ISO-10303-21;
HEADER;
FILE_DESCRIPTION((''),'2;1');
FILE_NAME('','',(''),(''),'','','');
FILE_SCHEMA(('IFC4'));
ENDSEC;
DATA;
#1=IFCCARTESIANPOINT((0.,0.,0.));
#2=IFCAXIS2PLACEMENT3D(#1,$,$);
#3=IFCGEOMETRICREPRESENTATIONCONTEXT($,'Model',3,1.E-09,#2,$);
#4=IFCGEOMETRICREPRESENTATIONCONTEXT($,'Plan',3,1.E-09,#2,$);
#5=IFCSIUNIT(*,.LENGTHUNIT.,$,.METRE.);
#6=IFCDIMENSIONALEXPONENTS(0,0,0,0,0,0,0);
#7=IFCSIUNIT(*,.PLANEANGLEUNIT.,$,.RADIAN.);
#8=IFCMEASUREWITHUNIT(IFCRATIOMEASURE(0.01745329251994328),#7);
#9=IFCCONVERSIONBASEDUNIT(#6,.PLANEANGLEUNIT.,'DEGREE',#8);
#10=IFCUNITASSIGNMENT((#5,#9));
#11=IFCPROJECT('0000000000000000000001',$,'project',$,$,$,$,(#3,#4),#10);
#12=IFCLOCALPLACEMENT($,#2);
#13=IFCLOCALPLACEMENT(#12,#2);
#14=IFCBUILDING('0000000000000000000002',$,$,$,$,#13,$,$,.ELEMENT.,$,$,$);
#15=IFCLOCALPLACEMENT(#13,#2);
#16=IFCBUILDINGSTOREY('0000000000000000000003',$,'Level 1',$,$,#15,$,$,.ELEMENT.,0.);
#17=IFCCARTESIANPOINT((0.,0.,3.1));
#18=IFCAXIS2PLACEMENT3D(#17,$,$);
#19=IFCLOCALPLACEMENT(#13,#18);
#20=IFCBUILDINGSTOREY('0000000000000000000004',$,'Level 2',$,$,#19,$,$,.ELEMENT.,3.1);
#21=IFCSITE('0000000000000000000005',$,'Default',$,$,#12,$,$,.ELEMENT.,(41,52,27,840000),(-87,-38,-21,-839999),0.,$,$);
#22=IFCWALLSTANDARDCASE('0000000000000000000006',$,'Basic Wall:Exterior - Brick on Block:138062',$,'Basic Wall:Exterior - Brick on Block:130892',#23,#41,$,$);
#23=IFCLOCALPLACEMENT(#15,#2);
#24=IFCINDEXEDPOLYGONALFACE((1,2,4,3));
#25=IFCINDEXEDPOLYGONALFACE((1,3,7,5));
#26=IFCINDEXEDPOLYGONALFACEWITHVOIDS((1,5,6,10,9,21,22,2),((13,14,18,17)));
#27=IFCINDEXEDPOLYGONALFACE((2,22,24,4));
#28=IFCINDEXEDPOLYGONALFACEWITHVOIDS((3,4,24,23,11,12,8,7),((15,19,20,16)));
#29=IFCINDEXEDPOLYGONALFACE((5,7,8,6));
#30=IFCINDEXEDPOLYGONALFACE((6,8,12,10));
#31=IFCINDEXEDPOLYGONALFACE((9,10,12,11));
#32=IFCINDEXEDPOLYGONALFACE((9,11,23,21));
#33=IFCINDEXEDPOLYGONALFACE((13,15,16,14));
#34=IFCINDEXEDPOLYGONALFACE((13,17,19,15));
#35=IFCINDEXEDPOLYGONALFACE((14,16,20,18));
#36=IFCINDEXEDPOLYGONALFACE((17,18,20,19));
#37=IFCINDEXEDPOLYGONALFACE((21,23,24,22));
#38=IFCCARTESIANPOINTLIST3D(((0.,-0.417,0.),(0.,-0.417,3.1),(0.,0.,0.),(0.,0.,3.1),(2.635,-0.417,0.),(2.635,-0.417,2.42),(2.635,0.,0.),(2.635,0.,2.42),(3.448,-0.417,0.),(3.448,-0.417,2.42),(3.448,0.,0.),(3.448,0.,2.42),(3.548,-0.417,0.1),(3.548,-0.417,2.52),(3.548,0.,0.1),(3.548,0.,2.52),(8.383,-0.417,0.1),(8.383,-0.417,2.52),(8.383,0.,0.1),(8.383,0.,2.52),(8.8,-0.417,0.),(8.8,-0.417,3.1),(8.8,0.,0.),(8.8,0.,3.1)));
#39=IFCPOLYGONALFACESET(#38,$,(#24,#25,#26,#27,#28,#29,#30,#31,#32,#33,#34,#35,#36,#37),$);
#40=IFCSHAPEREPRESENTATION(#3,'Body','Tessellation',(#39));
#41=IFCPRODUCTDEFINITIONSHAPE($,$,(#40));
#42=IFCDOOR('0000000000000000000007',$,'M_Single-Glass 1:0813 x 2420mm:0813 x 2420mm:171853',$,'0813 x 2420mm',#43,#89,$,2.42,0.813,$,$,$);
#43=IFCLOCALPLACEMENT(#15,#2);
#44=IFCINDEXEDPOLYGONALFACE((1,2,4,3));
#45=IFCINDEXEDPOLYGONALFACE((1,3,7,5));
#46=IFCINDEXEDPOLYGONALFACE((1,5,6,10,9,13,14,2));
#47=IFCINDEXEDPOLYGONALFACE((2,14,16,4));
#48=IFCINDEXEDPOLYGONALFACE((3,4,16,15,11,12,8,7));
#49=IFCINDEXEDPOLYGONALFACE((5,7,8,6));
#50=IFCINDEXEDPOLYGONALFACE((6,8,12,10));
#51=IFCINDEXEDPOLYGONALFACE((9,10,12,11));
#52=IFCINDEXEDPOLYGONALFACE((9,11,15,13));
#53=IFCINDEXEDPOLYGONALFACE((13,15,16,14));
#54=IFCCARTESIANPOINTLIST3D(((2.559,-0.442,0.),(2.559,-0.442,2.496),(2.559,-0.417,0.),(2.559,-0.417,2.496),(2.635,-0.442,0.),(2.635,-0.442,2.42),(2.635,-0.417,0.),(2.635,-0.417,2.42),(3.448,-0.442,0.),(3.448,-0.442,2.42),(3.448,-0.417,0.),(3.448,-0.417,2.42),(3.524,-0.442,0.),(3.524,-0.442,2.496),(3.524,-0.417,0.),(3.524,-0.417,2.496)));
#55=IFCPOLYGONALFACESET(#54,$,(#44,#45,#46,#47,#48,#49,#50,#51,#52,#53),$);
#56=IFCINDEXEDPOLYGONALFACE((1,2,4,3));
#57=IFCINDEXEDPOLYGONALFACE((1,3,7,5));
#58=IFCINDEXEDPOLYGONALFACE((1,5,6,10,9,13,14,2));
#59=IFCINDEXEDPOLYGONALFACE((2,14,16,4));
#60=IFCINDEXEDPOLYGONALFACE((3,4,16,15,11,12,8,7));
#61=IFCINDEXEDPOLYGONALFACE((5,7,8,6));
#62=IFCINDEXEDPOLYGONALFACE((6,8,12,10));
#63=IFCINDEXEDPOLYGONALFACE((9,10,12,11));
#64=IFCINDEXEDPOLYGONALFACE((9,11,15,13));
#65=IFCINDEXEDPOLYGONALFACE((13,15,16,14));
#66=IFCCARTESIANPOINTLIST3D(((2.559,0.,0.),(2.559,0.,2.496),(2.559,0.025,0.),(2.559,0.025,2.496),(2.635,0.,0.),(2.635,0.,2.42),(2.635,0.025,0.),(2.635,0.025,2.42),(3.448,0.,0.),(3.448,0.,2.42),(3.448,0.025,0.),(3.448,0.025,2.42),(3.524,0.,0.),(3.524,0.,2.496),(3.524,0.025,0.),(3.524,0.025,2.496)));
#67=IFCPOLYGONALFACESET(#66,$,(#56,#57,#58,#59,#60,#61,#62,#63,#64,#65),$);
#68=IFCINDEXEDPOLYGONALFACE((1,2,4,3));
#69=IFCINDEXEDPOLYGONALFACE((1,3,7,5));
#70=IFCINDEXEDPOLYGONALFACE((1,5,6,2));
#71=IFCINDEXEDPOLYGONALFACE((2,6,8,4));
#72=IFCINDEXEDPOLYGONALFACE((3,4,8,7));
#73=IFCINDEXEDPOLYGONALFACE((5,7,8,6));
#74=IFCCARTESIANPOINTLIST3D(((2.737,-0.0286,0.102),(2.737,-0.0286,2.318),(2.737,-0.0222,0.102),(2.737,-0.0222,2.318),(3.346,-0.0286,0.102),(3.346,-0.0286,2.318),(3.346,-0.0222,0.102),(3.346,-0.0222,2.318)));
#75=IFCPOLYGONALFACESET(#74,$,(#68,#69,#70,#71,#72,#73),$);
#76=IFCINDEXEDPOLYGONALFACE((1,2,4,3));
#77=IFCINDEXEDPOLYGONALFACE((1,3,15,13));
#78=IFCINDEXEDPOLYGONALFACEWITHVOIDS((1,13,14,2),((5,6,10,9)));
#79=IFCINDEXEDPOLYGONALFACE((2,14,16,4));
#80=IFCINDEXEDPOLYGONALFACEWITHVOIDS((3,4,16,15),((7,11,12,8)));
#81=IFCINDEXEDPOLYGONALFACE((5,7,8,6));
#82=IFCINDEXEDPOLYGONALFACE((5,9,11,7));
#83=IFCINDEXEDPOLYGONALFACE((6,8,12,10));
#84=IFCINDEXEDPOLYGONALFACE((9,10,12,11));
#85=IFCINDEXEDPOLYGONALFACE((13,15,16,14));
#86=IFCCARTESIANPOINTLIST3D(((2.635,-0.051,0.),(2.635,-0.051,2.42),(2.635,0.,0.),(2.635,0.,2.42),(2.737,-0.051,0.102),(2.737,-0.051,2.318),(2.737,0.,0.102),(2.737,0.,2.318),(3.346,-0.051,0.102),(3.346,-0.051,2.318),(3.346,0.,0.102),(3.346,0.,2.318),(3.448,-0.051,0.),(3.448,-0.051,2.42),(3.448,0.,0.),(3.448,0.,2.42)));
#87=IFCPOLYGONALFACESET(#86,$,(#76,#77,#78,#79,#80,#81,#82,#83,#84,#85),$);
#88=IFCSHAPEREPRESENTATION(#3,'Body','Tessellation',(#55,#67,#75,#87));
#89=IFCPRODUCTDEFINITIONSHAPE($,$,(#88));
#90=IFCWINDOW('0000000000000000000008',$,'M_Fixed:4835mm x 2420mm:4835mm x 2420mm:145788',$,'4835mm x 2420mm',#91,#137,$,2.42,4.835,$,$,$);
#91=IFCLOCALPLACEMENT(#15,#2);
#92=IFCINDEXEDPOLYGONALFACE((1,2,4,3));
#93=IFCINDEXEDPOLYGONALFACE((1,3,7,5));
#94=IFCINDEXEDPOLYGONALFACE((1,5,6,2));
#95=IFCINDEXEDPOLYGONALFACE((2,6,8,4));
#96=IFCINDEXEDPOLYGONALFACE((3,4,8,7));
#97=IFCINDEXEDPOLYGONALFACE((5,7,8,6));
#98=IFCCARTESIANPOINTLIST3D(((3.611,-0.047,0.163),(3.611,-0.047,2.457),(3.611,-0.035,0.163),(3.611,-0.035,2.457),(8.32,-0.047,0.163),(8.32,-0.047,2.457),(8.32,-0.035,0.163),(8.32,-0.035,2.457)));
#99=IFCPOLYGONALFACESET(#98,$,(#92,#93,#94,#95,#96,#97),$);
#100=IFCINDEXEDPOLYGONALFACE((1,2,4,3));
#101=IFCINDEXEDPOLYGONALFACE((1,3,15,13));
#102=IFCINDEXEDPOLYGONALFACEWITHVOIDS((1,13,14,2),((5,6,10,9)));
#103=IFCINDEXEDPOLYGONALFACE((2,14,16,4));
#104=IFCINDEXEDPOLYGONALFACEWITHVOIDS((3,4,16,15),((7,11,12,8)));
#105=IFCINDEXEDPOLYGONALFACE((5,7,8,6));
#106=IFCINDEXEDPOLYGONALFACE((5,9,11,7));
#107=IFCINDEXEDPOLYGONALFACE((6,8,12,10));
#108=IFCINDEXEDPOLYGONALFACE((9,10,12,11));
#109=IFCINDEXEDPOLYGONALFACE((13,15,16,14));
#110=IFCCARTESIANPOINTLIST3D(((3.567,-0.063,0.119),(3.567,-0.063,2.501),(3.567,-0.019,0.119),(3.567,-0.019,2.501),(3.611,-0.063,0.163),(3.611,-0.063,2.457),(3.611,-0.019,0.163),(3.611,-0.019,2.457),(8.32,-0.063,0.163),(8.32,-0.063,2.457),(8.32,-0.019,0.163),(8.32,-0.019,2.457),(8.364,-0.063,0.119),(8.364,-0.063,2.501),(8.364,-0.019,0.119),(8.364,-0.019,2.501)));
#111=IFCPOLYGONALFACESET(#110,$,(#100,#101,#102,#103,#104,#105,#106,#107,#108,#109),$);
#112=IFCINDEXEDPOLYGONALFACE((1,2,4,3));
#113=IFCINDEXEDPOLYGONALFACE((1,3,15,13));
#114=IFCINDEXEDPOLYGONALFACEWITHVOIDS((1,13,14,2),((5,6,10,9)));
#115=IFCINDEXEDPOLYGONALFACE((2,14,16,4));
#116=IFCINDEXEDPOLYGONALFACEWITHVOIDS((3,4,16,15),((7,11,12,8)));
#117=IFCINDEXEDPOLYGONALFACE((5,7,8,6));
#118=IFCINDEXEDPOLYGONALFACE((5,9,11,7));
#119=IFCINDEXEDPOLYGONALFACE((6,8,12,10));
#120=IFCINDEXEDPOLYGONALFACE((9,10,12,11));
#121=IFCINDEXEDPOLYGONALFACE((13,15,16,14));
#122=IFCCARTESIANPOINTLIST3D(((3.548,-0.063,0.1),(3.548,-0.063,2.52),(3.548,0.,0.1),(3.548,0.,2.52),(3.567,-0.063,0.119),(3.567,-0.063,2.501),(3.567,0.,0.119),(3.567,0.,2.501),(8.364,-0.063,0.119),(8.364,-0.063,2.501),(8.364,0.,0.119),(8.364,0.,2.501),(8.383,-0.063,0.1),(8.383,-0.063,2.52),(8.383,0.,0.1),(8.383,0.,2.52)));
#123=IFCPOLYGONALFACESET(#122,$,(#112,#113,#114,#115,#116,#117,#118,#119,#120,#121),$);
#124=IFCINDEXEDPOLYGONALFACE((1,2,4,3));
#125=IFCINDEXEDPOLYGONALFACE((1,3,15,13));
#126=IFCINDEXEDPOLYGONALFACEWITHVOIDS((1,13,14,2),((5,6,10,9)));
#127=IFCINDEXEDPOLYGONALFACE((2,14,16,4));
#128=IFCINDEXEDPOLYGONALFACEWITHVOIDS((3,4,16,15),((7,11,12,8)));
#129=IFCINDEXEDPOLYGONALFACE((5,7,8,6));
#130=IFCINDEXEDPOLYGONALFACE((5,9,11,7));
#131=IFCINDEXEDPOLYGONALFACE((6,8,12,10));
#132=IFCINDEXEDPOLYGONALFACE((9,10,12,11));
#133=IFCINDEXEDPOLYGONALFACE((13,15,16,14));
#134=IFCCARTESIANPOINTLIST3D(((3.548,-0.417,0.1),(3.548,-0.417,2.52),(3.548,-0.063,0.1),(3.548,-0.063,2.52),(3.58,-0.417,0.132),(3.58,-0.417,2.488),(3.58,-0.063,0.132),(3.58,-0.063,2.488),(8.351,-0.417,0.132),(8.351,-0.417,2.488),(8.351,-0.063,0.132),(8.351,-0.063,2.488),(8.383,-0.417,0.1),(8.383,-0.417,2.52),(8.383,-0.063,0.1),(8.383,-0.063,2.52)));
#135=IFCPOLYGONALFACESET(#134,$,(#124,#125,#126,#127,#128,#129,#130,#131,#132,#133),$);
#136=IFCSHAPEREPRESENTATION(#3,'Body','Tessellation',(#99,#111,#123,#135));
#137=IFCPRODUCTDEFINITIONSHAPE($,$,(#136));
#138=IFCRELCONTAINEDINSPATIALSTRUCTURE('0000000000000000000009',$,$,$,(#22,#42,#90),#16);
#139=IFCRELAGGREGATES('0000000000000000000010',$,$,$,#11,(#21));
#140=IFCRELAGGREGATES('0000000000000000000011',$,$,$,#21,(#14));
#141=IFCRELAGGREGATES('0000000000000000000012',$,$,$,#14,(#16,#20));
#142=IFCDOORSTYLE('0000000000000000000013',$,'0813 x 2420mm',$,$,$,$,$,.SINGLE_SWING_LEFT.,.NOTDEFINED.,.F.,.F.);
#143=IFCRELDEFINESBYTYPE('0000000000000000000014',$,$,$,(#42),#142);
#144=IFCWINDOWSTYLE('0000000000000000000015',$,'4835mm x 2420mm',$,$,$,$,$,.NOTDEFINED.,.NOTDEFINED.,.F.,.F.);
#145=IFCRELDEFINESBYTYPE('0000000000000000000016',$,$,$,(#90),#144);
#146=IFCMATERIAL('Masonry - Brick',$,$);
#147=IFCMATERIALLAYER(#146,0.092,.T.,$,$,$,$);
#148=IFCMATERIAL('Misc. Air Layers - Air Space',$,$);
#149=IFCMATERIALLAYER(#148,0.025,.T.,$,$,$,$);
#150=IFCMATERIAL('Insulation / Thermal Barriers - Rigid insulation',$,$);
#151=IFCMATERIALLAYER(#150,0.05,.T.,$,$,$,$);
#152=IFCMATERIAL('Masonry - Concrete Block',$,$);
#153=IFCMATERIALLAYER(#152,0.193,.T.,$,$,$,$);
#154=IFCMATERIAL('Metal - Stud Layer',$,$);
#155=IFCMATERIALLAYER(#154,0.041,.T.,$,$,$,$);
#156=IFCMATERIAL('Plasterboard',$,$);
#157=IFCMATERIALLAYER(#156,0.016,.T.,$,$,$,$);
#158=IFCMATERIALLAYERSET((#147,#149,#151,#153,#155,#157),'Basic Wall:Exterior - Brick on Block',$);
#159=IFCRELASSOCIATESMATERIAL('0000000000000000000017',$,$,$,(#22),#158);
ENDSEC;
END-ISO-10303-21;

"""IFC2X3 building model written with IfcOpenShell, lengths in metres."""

from ifc_helpers import new_model, entity, si_unit, converted_unit, frame, frame_2d, origin, origin_2d_with_axis, place, context, project, spatial, polyline, rectangle, outline, extrude, source, transform, mapped, material, layer, layer_set, layer_usage, type_object, type_shapes, element, fill, save


model = new_model("IFC2X3")

# Units and contexts
model_context = context("Model", 3, precision=1e-09, world=origin())
plan_context = context("Plan", 3, precision=1e-09, world=origin())
ifc_project = project(units=[si_unit("LENGTHUNIT", "METRE"), converted_unit("PLANEANGLEUNIT", "DEGREE", entity("IfcRatioMeasure", 0.01745329251994328), si_unit("PLANEANGLEUNIT", "RADIAN"), dimensions=[0, 0, 0, 0, 0, 0, 0])], contexts=[model_context, plan_context])

# Site, building, storey
site_placement = place(None, origin())
site = spatial("IfcSite", under=ifc_project, at=site_placement, Name="Default", CompositionType="ELEMENT", RefLatitude=(41, 52, 27, 840000), RefLongitude=(-87, -38, -21, -839999), RefElevation=0.0)
building_placement = place(site_placement, origin())
building = spatial("IfcBuilding", under=site, at=building_placement, CompositionType="ELEMENT")
storey_1_placement = place(building_placement, origin())
storey_1 = spatial("IfcBuildingStorey", under=building, at=storey_1_placement, Name="Level 1", CompositionType="ELEMENT", Elevation=0.0)

# Wall, openings, door, window
ifc_material_1 = material(Name="Masonry - Brick")
ifc_layer_1 = layer(ifc_material_1, 0.092, ventilated=True)
ifc_material_2 = material(Name="Misc. Air Layers - Air Space")
ifc_layer_2 = layer(ifc_material_2, 0.025, ventilated=True)
ifc_material_3 = material(Name="Insulation / Thermal Barriers - Rigid insulation")
ifc_layer_3 = layer(ifc_material_3, 0.05, ventilated=True)
ifc_material_4 = material(Name="Masonry - Concrete Block")
ifc_layer_4 = layer(ifc_material_4, 0.193, ventilated=True)
ifc_material_5 = material(Name="Metal - Stud Layer")
ifc_layer_5 = layer(ifc_material_5, 0.041, ventilated=True)
ifc_material_6 = material(Name="Plasterboard")
ifc_layer_6 = layer(ifc_material_6, 0.016, ventilated=True)
ifc_layer_set_1 = layer_set([ifc_layer_1, ifc_layer_2, ifc_layer_3, ifc_layer_4, ifc_layer_5, ifc_layer_6], Name="Basic Wall:Exterior - Brick on Block")
ifc_layer_usage_1 = layer_usage(ifc_layer_set_1, "AXIS2", "NEGATIVE", 0.2085)
wall_1_placement = place(storey_1_placement, frame((0.0, -0.2085, 0.0)))
wall_1 = element("IfcWallStandardCase", 1, at=wall_1_placement, inside=storey_1, material=ifc_layer_usage_1, Name="Basic Wall:Exterior - Brick on Block:138062", ObjectType="Basic Wall:Exterior - Brick on Block:130892", context=model_context, shape_type="SweptSolid", body=[
    extrude(rectangle(XDim=8.8, YDim=0.417, at=frame_2d((4.4, 0.0), x_axis=(-1.0, 0.0))), origin(), (0.0, 0.0, 1.0), 3.1),
])
opening_1_placement = place(wall_1_placement, frame((2.635, -0.2085, 0.0)))
opening_1 = element("IfcOpeningElement", 2, at=opening_1_placement, cuts=wall_1, ObjectType="Opening", context=model_context, shape_type="SweptSolid", body=[
    extrude(rectangle(XDim=0.813, YDim=2.42, at=frame_2d((1.21, 0.4065), x_axis=(0.0, -1.0))), frame((0.0, 0.0, 0.0), z_axis=(0.0, 1.0, 0.0), x_axis=(0.0, 0.0, 1.0)), (0.0, 0.0, 1.0), 0.417),
])
opening_2_placement = place(wall_1_placement, frame((3.548, -0.2085, 0.1)))
opening_2 = element("IfcOpeningElement", 3, at=opening_2_placement, cuts=wall_1, ObjectType="Opening", context=model_context, shape_type="SweptSolid", body=[
    extrude(rectangle(XDim=2.42, YDim=4.835, at=frame_2d((1.21, 2.4175), x_axis=(1.0, 0.0))), frame((0.0, 0.0, 0.0), z_axis=(0.0, 1.0, 0.0), x_axis=(0.0, 0.0, 1.0)), (0.0, 0.0, 1.0), 0.417),
])
door_style_1 = type_object("IfcDoorStyle", Name="0813 x 2420mm", ConstructionType="NOTDEFINED", OperationType="SINGLE_SWING_LEFT", ParameterTakesPrecedence=False, Sizeable=False)
shared_shape_1 = source(origin(), model_context, "Body", "SweptSolid", [
    extrude(outline(polyline([(-0.4065, -1.191), (-0.4065, 1.229), (-0.4825, 1.229), (-0.4825, -1.267), (0.4825, -1.267), (0.4825, 1.229), (0.4065, 1.229), (0.4065, -1.191), (-0.4065, -1.191)])), frame((0.4065, 0.0, 1.229), z_axis=(0.0, 1.0, 0.0), x_axis=(1.0, 0.0, 0.0)), (0.0, 0.0, -1.0), 0.025),
    extrude(outline(polyline([(-0.4065, -1.191), (-0.4065, 1.229), (-0.4825, 1.229), (-0.4825, -1.267), (0.4825, -1.267), (0.4825, 1.229), (0.4065, 1.229), (0.4065, -1.191), (-0.4065, -1.191)])), frame((0.4065, 0.442, 1.229), z_axis=(0.0, 1.0, 0.0), x_axis=(1.0, 0.0, 0.0)), (0.0, 0.0, -1.0), 0.025),
    extrude(rectangle(XDim=0.609, YDim=0.0064, at=origin_2d_with_axis()), frame((0.4065, 0.3916, 0.102)), (0.0, 0.0, 1.0), 2.216),
    extrude(outline(polyline([(-1.21, -0.4065), (1.21, -0.4065), (1.21, 0.4065), (-1.21, 0.4065), (-1.21, -0.4065)]), holes=[polyline([(-1.108, 0.3045), (1.108, 0.3045), (1.108, -0.3045), (-1.108, -0.3045), (-1.108, 0.3045)])]), frame((0.4065, 0.417, 1.21), z_axis=(0.0, -1.0, 0.0), x_axis=(0.0, 0.0, -1.0)), (0.0, 0.0, 1.0), 0.051),
])
type_shapes(door_style_1, [shared_shape_1])
door_1_placement = place(opening_1_placement, origin())
door_1 = element("IfcDoor", 4, at=door_1_placement, inside=storey_1, type_object=door_style_1, Name="M_Single-Glass 1:0813 x 2420mm:0813 x 2420mm:171853", ObjectType="0813 x 2420mm", OverallHeight=2.42, OverallWidth=0.813, context=model_context, shape_type="MappedRepresentation", body=[
    mapped(shared_shape_1, transform((0.0, 0.0, 0.0), scale=1.0)),
])
fill(opening_1, door_1)
window_style_1 = type_object("IfcWindowStyle", Name="4835mm x 2420mm", ConstructionType="NOTDEFINED", OperationType="NOTDEFINED", ParameterTakesPrecedence=False, Sizeable=False)
shared_shape_2 = source(origin(), model_context, "Body", "SweptSolid", [
    extrude(rectangle(XDim=0.012, YDim=4.709, at=origin_2d_with_axis()), frame((2.4175, 0.376, 0.063), z_axis=(0.0, 0.0, 1.0), x_axis=(0.0, -1.0, 0.0)), (0.0, 0.0, 1.0), 2.294),
    extrude(outline(polyline([(-2.3985, -1.191), (2.3985, -1.191), (2.3985, 1.191), (-2.3985, 1.191), (-2.3985, -1.191)]), holes=[polyline([(-2.3545, -1.147), (-2.3545, 1.147), (2.3545, 1.147), (2.3545, -1.147), (-2.3545, -1.147)])]), frame((2.4175, 0.354, 1.21), z_axis=(0.0, 1.0, 0.0), x_axis=(1.0, 0.0, 0.0)), (0.0, 0.0, 1.0), 0.044),
    extrude(outline(polyline([(-2.4175, -1.21), (2.4175, -1.21), (2.4175, 1.21), (-2.4175, 1.21), (-2.4175, -1.21)]), holes=[polyline([(-2.3985, -1.191), (-2.3985, 1.191), (2.3985, 1.191), (2.3985, -1.191), (-2.3985, -1.191)])]), frame((2.4175, 0.354, 1.21), z_axis=(0.0, 1.0, 0.0), x_axis=(1.0, 0.0, 0.0)), (0.0, 0.0, 1.0), 0.063),
    extrude(outline(polyline([(-2.4175, -1.21), (2.4175, -1.21), (2.4175, 1.21), (-2.4175, 1.21), (-2.4175, -1.21)]), holes=[polyline([(-2.3855, -1.178), (-2.3855, 1.178), (2.3855, 1.178), (2.3855, -1.178), (-2.3855, -1.178)])]), frame((2.4175, 0.0, 1.21), z_axis=(0.0, 1.0, 0.0), x_axis=(1.0, 0.0, 0.0)), (0.0, 0.0, 1.0), 0.354),
])
type_shapes(window_style_1, [shared_shape_2])
window_1_placement = place(opening_2_placement, origin())
window_1 = element("IfcWindow", 5, at=window_1_placement, inside=storey_1, type_object=window_style_1, Name="M_Fixed:4835mm x 2420mm:4835mm x 2420mm:145788", ObjectType="4835mm x 2420mm", OverallHeight=2.42, OverallWidth=4.835, context=model_context, shape_type="MappedRepresentation", body=[
    mapped(shared_shape_2, transform((0.0, 0.0, 0.0), scale=1.0)),
])
fill(opening_2, window_1)

# Shared definitions
storey_2_placement = place(building_placement, frame((0.0, 0.0, 3.1)))
storey_2 = spatial("IfcBuildingStorey", under=building, at=storey_2_placement, Name="Level 2", CompositionType="ELEMENT", Elevation=3.1)

save(model, "model.ifc")
